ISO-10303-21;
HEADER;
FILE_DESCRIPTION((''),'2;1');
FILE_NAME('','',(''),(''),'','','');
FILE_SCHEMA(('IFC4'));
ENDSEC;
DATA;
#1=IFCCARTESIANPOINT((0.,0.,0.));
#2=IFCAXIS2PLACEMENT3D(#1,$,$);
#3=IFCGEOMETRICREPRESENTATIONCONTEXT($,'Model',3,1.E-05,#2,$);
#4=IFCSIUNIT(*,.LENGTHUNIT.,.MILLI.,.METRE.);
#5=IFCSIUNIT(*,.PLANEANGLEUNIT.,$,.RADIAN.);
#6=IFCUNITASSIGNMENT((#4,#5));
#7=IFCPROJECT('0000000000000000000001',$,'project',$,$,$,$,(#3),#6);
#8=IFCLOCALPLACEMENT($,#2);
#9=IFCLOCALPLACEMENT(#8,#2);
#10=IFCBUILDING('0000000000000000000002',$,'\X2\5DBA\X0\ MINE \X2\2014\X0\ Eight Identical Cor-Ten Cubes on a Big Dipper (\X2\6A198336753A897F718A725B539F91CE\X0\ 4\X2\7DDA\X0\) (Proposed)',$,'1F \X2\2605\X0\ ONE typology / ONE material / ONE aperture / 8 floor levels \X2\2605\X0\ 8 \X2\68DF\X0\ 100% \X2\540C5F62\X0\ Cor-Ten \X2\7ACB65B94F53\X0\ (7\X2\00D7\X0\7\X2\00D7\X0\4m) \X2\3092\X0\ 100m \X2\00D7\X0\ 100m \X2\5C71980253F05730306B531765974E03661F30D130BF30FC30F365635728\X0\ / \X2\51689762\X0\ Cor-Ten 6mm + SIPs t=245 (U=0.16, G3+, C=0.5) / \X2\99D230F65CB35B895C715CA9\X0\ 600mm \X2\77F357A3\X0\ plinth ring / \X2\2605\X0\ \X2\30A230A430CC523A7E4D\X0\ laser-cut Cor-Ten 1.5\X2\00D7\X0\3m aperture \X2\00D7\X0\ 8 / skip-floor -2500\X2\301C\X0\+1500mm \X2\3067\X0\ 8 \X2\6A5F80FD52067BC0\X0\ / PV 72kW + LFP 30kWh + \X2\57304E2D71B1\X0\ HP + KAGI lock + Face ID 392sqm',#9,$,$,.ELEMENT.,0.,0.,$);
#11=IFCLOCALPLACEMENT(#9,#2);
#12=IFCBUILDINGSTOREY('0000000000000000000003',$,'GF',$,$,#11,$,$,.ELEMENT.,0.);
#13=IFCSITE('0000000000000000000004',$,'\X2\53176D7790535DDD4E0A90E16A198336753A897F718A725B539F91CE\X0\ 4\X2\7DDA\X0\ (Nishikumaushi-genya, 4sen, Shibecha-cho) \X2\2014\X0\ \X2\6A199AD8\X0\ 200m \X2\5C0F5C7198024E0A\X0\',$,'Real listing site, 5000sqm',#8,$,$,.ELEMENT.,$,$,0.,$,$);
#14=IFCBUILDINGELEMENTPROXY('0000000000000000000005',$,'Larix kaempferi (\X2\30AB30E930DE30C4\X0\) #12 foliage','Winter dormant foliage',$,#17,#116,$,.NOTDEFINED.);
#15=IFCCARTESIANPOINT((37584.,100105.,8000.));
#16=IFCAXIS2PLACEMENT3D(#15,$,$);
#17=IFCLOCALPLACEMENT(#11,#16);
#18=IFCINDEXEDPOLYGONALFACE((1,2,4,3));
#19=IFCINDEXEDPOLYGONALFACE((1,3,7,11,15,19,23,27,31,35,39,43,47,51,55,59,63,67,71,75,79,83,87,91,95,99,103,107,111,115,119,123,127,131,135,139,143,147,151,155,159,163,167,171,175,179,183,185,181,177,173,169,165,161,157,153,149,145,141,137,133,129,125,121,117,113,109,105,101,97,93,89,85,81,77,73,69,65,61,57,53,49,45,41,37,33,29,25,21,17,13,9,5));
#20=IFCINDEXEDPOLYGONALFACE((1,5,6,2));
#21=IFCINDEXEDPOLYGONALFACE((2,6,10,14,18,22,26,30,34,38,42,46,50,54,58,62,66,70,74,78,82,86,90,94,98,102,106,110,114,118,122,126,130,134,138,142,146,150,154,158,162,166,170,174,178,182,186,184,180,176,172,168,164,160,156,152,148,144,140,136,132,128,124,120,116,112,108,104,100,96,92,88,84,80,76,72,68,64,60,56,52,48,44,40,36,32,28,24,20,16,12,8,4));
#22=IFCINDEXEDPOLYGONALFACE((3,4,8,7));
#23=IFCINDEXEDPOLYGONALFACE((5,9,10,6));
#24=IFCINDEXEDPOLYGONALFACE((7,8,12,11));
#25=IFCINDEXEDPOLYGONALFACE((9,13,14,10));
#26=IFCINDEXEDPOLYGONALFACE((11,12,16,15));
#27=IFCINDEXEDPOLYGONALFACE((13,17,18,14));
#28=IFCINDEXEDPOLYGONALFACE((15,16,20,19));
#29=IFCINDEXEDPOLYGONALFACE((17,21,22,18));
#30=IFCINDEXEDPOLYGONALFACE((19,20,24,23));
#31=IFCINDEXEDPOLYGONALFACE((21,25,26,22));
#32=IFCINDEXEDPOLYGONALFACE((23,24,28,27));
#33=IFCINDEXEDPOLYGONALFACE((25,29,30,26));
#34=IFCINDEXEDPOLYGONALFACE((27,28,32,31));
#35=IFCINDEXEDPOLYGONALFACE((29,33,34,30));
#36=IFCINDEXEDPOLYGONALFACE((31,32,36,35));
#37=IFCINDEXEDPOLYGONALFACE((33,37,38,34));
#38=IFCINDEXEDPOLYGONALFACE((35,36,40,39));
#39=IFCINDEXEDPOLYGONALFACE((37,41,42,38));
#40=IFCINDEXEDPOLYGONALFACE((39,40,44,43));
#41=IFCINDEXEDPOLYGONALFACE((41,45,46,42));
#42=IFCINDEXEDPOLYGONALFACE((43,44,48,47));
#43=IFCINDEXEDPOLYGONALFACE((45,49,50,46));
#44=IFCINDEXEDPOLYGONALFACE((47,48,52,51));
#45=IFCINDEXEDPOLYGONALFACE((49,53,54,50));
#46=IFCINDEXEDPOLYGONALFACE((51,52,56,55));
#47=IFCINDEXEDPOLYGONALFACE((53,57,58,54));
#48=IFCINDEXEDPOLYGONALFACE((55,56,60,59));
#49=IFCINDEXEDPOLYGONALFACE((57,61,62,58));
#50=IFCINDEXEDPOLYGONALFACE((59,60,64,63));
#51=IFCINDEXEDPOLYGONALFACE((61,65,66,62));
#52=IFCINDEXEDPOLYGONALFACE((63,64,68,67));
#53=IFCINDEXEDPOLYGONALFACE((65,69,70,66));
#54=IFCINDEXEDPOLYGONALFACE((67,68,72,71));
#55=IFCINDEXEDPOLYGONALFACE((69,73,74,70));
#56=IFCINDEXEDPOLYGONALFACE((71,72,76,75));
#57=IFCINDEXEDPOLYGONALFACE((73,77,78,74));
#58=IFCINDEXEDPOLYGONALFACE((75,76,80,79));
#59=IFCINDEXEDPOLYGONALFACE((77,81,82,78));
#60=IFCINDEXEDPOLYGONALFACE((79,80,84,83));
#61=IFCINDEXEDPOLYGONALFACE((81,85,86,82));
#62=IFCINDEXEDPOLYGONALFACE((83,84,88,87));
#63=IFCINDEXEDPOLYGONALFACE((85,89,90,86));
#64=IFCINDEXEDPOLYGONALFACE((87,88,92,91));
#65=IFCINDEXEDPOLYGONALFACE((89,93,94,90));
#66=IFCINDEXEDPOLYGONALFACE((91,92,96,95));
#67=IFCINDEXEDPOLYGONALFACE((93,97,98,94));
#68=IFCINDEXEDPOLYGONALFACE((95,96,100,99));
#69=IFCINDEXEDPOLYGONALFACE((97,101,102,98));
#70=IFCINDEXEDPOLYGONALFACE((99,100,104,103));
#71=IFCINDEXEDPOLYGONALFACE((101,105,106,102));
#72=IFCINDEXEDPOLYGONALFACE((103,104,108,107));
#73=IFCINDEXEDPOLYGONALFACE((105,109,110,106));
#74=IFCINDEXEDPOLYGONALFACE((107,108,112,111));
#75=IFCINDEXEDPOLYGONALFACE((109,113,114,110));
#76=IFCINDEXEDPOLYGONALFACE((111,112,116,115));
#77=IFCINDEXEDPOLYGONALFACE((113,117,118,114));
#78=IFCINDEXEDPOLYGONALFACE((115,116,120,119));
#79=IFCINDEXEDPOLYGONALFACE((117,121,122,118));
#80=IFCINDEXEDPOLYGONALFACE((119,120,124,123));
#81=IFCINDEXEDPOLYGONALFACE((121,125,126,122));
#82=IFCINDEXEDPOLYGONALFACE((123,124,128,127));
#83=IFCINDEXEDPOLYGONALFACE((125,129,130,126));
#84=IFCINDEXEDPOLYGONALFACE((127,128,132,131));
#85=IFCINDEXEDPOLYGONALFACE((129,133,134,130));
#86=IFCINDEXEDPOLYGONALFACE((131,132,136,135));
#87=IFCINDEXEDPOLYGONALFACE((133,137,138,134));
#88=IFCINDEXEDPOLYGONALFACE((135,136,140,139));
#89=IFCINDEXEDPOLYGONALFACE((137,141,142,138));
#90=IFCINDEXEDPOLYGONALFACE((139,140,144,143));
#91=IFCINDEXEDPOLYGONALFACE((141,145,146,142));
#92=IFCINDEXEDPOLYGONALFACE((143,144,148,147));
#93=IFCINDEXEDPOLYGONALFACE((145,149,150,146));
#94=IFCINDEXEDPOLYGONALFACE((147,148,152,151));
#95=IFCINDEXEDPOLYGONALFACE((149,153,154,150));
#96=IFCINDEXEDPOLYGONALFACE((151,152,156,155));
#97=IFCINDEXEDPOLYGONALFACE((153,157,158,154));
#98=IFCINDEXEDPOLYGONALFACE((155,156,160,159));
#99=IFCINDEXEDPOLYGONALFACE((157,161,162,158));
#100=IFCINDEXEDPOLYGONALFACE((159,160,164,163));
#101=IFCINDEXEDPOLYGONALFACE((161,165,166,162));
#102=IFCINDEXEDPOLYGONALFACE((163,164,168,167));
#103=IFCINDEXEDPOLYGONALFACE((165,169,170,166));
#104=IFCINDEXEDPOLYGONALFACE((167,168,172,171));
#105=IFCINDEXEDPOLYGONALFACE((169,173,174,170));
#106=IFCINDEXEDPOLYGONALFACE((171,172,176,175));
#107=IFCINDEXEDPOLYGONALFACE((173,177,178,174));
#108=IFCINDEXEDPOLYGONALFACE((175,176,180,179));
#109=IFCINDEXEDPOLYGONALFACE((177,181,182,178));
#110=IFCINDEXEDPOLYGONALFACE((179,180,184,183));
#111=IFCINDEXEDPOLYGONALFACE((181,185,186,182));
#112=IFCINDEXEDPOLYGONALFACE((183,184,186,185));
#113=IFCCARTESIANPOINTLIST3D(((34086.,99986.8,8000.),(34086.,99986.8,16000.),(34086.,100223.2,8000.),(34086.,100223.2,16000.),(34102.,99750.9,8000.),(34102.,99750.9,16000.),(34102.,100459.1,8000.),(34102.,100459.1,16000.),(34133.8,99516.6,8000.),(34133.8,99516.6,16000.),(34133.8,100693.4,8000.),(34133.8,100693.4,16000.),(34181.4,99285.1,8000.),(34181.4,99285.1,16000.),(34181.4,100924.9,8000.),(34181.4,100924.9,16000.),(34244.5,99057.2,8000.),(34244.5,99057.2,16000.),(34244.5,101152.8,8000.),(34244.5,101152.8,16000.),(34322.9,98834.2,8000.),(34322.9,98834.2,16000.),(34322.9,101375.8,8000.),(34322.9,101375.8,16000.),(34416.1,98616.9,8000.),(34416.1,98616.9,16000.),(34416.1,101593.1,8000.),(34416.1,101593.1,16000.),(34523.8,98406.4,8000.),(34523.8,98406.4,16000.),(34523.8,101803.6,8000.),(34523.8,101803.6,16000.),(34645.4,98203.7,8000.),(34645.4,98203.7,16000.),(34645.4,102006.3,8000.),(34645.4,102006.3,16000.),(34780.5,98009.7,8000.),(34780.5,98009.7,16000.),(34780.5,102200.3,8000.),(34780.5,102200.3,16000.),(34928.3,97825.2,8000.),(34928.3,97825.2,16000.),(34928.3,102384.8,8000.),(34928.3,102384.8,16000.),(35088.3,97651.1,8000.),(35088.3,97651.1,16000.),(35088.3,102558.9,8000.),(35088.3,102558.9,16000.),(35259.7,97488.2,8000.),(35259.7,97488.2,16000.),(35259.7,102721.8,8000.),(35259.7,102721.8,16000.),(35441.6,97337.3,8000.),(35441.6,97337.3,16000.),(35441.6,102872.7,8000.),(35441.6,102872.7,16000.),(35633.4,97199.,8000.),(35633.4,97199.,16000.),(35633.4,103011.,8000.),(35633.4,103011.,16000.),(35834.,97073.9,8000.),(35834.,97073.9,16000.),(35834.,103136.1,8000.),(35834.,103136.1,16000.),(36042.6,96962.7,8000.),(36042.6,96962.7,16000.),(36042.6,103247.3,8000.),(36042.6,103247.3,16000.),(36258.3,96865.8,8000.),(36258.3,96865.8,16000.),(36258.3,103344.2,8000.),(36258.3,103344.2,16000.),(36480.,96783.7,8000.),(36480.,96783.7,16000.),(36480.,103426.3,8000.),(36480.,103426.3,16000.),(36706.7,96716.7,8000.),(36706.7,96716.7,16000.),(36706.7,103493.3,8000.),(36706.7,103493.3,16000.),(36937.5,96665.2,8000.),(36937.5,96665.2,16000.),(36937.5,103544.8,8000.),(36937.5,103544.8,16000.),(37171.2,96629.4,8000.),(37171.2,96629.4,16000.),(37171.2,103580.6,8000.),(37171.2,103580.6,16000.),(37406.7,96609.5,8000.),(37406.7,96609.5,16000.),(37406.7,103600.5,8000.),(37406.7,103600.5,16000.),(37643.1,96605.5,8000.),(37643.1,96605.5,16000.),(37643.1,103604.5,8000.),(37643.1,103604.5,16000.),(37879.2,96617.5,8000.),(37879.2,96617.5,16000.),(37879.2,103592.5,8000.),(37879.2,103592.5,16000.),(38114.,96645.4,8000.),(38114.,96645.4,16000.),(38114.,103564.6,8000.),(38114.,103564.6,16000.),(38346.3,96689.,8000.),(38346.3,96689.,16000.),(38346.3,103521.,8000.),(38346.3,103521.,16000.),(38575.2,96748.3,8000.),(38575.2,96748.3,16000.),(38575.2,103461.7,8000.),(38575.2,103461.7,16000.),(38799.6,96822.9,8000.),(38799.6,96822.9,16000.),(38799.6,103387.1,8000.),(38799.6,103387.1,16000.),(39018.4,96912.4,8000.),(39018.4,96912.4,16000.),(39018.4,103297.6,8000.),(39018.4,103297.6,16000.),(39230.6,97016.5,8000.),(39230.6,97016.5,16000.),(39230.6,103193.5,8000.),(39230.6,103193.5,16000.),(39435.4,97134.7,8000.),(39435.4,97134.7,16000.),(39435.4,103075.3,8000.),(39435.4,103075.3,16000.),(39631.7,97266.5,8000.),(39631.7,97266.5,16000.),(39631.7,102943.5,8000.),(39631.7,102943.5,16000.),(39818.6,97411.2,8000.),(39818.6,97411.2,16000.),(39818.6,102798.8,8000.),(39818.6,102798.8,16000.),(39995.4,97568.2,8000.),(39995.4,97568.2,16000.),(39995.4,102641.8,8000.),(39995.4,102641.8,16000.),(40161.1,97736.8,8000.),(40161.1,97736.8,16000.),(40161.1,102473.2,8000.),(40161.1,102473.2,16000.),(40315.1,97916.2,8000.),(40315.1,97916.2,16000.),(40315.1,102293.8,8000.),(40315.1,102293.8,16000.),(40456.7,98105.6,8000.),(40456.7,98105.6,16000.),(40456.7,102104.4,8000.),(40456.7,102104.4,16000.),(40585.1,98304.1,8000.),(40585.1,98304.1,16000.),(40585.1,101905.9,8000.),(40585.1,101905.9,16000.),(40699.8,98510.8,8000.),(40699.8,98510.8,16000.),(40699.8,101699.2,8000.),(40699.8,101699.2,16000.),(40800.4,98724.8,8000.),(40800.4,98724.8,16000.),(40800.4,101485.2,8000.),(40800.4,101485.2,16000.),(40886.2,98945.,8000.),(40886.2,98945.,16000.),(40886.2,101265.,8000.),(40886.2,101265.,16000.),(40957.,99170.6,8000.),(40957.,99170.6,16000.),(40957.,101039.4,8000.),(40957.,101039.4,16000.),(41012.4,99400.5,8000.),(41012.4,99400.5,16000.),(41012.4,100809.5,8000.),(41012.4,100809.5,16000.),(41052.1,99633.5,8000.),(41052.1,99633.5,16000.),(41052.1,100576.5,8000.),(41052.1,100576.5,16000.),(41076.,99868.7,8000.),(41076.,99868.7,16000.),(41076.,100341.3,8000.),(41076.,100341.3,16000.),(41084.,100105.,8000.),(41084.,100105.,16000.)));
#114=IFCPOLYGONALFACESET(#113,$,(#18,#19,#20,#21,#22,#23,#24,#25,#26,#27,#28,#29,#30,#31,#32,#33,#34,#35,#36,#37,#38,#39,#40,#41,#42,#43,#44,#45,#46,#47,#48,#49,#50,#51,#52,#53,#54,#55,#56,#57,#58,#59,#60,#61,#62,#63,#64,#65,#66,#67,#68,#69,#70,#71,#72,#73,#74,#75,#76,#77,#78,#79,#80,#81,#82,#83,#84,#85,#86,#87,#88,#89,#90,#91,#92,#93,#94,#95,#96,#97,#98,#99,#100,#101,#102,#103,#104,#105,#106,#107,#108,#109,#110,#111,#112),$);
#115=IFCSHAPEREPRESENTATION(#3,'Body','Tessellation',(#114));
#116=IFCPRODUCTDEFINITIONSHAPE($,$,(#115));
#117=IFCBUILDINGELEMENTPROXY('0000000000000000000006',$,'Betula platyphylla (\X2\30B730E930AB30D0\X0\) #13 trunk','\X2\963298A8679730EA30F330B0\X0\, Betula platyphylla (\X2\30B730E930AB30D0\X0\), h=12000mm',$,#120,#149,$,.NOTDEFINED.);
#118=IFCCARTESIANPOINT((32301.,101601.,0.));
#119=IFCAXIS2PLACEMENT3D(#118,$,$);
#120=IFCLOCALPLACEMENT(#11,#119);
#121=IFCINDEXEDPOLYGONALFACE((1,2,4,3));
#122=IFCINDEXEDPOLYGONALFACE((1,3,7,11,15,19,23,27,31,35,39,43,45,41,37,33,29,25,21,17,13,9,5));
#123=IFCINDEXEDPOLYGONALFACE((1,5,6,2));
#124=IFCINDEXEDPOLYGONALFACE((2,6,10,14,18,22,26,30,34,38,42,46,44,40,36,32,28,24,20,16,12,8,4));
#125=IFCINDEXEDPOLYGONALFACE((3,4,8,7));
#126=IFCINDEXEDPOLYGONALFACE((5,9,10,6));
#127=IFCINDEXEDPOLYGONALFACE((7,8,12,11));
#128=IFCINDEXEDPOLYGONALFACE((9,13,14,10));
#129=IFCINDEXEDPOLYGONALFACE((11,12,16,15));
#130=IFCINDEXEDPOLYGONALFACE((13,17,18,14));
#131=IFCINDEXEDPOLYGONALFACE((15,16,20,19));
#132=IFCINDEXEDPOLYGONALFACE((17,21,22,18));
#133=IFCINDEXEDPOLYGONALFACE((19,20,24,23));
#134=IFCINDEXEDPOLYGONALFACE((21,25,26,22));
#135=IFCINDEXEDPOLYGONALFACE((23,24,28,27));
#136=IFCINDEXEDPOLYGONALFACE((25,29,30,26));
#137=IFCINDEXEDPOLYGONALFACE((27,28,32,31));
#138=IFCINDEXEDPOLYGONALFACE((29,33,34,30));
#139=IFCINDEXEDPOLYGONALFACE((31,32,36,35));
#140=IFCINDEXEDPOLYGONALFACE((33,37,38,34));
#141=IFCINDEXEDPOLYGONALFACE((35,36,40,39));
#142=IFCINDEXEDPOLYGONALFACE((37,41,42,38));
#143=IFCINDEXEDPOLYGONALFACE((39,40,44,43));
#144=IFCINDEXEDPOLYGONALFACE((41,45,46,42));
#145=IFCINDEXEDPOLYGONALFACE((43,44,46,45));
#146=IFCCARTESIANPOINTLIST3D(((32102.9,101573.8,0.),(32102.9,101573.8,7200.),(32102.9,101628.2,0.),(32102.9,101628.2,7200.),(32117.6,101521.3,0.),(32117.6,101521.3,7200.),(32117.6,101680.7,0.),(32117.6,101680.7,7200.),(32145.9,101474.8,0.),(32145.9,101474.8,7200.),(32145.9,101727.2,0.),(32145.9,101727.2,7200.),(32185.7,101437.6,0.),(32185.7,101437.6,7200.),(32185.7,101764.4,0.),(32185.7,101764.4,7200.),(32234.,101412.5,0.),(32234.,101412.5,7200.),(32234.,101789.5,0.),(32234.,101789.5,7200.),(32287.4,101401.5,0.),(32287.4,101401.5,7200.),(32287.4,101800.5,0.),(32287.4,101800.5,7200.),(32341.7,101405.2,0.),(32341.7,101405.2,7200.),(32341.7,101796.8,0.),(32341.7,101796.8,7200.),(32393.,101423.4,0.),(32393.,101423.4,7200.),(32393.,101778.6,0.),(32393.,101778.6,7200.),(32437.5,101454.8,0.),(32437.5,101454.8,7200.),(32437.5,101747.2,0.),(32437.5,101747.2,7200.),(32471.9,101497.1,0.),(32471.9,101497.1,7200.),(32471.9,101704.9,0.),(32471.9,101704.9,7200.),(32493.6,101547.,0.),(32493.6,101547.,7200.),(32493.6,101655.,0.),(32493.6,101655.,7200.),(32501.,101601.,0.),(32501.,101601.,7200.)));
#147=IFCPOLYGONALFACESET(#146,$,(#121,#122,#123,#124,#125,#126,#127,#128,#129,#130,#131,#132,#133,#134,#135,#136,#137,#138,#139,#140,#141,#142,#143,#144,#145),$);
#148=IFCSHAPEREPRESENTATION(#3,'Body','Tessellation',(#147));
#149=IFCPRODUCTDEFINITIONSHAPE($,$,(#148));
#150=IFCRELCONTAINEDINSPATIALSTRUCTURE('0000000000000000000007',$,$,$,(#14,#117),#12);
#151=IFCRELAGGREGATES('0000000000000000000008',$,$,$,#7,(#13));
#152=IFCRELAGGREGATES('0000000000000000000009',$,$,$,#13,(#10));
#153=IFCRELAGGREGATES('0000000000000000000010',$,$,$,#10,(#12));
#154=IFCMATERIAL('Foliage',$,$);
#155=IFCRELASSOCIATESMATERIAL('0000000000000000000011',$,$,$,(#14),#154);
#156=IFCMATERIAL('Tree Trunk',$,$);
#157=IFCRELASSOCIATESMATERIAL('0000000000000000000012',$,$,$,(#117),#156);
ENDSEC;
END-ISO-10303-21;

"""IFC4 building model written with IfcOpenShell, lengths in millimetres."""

from ifc_helpers import new_model, si_unit, frame, origin, origin_2d, place, context, project, spatial, circle, extrude, material, element, save


model = new_model("IFC4")

# Units and contexts
model_context = context("Model", 3, precision=1e-05, world=origin())
ifc_project = project(units=[si_unit("LENGTHUNIT", "METRE", prefix="MILLI"), si_unit("PLANEANGLEUNIT", "RADIAN")], contexts=[model_context])

# Site, building, storey
site_placement = place(None, origin())
site = spatial("IfcSite", under=ifc_project, at=site_placement, Name="北海道川上郡標茶町西熊牛原野 4線 (Nishikumaushi-genya, 4sen, Shibecha-cho) — 標高 200m 小山頂上", ObjectType="Real listing site, 5000sqm", CompositionType="ELEMENT", RefElevation=0.0)
building_placement = place(site_placement, origin())
building = spatial("IfcBuilding", under=site, at=building_placement, Name="嶺 MINE — Eight Identical Cor-Ten Cubes on a Big Dipper (標茶町西熊牛原野 4線) (Proposed)", ObjectType="1F ★ ONE typology / ONE material / ONE aperture / 8 floor levels ★ 8 棟 100% 同形 Cor-Ten 立方体 (7×7×4m) を 100m × 100m 山頂台地に北斗七星パターン散在 / 全面 Cor-Ten 6mm + SIPs t=245 (U=0.16, G3+, C=0.5) / 駒ヶ岳安山岩 600mm 石垣 plinth ring / ★ アイヌ刺繍 laser-cut Cor-Ten 1.5×3m aperture × 8 / skip-floor -2500〜+1500mm で 8 機能分節 / PV 72kW + LFP 30kWh + 地中熱 HP + KAGI lock + Face ID 392sqm", CompositionType="ELEMENT", ElevationOfRefHeight=0.0, ElevationOfTerrain=0.0)
storey_placement = place(building_placement, origin())
storey = spatial("IfcBuildingStorey", under=building, at=storey_placement, Name="GF", CompositionType="ELEMENT", Elevation=0.0)

# Building element proxies
ifc_material_1 = material(Name="Foliage")
ifc_material_2 = material(Name="Tree Trunk")
proxy_1_placement = place(storey_placement, frame((37584.0, 100105.0, 8000.0)))
element("IfcBuildingElementProxy", 1, at=proxy_1_placement, inside=storey, material=ifc_material_1, Name="Larix kaempferi (カラマツ) #12 foliage", Description="Winter dormant foliage", PredefinedType="NOTDEFINED", context=model_context, shape_type="SweptSolid", body=[
    extrude(circle(Radius=3500.0, at=origin_2d()), frame((37584.0, 100105.0, 8000.0)), (0.0, 0.0, 1.0), 8000.0),
])
proxy_2_placement = place(storey_placement, frame((32301.0, 101601.0, 0.0)))
element("IfcBuildingElementProxy", 2, at=proxy_2_placement, inside=storey, material=ifc_material_2, Name="Betula platyphylla (シラカバ) #13 trunk", Description="防風林リング, Betula platyphylla (シラカバ), h=12000mm", PredefinedType="NOTDEFINED", context=model_context, shape_type="SweptSolid", body=[
    extrude(circle(Radius=200.0, at=origin_2d()), frame((32301.0, 101601.0, 0.0)), (0.0, 0.0, 1.0), 7200.0),
])

save(model, "model.ifc")
